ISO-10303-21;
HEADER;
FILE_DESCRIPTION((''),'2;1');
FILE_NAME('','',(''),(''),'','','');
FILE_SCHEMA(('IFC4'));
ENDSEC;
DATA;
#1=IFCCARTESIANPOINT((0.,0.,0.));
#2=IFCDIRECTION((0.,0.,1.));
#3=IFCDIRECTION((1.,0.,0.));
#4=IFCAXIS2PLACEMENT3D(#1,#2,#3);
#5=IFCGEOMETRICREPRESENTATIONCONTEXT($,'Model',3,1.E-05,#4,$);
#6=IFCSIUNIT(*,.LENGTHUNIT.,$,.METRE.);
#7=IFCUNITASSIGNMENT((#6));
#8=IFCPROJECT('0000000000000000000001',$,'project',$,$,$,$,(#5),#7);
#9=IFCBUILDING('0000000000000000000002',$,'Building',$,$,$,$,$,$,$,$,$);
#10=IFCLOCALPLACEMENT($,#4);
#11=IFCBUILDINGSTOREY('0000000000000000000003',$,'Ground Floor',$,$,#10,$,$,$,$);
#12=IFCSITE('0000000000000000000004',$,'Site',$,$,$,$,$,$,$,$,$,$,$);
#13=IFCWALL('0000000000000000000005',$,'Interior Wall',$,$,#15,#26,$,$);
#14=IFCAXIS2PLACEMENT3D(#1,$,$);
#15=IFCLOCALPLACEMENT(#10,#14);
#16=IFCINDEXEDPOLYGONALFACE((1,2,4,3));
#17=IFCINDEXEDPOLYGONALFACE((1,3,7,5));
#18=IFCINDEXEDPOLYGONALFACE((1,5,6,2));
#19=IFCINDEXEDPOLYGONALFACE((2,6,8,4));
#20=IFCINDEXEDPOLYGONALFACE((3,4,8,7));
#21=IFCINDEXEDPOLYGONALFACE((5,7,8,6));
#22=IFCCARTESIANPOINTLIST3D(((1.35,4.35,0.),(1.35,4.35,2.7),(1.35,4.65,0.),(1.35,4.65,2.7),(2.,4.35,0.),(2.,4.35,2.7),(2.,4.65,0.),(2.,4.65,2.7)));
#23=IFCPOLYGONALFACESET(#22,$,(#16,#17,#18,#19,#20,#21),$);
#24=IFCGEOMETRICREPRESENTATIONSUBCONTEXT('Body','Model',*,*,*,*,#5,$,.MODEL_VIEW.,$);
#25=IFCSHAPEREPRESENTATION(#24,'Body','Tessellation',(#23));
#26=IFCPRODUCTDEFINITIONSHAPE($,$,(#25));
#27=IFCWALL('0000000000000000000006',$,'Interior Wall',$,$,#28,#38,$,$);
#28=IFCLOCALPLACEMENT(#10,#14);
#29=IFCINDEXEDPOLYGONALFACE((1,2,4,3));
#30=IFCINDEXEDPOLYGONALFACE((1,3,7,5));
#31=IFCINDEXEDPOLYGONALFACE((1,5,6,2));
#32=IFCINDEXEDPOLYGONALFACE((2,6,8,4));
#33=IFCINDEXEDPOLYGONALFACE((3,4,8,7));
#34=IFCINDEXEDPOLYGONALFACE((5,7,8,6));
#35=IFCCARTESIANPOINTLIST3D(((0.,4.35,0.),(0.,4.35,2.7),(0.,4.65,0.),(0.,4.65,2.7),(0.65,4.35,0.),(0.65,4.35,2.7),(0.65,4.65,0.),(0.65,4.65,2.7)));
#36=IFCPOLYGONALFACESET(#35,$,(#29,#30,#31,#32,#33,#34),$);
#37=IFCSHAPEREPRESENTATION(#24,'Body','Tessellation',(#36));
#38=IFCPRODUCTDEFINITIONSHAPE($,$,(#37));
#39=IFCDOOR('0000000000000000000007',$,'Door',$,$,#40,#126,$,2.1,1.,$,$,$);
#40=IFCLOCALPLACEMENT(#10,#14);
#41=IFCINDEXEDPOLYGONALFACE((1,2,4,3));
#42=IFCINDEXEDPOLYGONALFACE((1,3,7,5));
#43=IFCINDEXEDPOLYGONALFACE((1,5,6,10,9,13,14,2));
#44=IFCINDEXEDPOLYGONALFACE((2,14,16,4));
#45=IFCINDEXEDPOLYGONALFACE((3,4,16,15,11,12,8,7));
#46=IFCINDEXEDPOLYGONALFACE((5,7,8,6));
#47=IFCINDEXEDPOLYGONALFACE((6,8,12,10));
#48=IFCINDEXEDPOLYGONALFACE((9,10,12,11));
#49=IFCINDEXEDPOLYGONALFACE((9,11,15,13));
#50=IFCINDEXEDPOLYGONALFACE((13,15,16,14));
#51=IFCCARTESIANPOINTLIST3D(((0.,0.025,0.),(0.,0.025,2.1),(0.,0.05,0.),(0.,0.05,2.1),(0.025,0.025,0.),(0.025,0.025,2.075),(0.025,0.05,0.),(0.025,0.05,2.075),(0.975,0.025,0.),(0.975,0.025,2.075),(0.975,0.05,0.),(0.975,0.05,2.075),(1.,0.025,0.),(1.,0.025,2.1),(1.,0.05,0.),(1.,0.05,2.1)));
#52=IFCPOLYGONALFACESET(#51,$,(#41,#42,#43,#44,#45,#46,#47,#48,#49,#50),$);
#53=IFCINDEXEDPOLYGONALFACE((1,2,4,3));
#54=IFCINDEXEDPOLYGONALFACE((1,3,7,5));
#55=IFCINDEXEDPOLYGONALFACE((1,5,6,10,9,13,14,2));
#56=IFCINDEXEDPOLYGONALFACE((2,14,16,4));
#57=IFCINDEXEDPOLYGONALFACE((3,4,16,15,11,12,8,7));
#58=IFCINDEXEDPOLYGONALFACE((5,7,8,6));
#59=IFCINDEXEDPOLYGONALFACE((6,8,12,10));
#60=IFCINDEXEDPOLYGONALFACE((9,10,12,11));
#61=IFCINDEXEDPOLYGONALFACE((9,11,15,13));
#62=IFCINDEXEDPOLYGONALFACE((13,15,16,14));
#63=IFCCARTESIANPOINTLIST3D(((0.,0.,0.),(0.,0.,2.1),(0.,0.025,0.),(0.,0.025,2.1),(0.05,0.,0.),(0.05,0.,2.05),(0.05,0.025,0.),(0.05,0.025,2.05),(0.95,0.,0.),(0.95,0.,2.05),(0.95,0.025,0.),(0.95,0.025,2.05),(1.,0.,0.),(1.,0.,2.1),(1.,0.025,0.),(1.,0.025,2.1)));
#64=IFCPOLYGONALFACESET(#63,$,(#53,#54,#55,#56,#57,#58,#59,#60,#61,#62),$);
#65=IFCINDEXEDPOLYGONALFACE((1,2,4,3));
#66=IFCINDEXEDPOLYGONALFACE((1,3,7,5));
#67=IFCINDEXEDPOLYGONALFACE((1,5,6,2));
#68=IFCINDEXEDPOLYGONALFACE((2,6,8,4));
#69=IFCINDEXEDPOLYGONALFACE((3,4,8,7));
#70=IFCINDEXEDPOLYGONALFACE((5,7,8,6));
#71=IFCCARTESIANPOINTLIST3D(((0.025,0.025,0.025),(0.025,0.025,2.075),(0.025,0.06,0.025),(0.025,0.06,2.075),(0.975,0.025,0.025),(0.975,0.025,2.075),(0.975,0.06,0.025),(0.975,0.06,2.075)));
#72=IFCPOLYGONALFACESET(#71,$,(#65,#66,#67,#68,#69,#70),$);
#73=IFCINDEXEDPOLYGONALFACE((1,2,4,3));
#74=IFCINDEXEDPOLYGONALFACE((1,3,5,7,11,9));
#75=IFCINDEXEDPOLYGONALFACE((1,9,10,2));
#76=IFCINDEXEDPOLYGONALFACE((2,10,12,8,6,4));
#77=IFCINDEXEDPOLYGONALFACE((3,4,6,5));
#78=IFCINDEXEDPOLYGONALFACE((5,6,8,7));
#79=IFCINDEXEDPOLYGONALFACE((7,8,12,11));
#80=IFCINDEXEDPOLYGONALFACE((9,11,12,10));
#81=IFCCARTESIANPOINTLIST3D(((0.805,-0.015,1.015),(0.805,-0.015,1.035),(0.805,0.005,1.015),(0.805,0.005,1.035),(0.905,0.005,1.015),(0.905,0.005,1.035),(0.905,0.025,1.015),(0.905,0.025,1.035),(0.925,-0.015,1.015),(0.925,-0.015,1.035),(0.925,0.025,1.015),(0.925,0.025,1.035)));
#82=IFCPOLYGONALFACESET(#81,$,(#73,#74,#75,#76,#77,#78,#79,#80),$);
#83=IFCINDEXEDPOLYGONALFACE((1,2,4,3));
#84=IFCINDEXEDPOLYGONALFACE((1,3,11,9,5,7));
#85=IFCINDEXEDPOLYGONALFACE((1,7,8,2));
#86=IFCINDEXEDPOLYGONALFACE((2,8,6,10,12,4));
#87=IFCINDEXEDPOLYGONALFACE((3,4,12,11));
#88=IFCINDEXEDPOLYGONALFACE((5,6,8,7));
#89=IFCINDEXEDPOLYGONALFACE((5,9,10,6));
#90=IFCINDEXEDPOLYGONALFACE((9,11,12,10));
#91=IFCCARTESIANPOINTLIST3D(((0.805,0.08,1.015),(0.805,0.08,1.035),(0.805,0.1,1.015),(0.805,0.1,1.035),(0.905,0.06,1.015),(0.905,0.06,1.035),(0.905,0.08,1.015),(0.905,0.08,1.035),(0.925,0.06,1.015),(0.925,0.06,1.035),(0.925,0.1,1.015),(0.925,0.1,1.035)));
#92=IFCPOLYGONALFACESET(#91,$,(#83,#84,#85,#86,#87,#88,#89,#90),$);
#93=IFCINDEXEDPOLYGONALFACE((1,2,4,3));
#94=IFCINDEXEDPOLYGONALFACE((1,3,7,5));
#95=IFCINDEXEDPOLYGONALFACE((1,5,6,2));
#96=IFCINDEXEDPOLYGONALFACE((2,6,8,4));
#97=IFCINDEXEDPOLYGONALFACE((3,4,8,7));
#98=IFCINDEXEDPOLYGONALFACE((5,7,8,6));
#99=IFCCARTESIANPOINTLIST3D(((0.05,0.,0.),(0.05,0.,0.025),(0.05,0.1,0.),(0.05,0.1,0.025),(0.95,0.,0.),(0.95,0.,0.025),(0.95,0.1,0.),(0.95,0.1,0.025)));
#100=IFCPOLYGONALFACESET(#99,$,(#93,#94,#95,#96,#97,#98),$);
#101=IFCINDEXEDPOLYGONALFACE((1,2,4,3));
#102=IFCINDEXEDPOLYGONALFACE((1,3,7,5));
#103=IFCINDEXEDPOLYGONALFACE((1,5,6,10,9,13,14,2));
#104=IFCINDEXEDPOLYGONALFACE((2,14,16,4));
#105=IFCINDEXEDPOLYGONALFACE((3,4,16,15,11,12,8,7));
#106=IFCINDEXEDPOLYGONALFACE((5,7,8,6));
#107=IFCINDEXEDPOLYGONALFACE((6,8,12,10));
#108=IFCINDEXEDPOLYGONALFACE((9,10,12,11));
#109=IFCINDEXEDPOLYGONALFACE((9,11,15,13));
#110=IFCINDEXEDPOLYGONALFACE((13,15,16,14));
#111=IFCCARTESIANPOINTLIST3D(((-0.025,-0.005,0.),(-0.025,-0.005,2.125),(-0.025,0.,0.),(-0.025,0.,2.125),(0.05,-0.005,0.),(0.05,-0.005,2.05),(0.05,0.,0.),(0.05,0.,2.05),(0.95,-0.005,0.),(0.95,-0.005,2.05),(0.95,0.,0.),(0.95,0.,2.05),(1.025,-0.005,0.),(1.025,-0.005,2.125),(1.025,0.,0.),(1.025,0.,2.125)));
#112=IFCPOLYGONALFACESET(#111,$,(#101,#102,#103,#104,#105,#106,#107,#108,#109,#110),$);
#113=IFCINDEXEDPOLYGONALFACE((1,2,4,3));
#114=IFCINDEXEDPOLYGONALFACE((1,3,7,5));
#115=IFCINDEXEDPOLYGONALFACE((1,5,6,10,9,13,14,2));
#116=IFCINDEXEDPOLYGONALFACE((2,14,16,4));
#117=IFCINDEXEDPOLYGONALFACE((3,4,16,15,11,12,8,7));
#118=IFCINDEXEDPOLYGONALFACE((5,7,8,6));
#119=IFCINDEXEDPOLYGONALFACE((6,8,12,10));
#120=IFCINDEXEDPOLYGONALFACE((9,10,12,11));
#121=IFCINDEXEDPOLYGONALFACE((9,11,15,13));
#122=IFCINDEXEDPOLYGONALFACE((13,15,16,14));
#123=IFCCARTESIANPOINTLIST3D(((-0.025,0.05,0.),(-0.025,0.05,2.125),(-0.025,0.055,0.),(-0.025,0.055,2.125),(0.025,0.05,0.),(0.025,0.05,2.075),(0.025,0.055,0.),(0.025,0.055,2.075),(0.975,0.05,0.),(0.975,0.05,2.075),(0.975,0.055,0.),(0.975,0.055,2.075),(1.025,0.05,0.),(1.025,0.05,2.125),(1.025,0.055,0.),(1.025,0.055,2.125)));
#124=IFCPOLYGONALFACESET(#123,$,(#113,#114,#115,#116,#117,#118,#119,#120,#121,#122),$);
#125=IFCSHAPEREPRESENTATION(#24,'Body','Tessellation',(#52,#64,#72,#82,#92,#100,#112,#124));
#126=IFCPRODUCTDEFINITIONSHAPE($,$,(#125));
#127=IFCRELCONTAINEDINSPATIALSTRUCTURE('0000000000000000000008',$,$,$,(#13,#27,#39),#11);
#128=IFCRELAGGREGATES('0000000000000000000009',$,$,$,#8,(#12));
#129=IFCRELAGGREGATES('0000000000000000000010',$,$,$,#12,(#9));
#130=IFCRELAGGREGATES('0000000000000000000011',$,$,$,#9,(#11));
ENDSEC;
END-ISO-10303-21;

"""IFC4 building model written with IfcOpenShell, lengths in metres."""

from ifc_helpers import new_model, si_unit, frame, origin_with_axes, place, context, subcontext, project, spatial, line, indexed_curve, outline, extrude, element, save


model = new_model("IFC4")

# Units and contexts
model_context = context("Model", 3, precision=1e-05, world=origin_with_axes())
body_context = subcontext(model_context, "Body", "Model", "MODEL_VIEW")
ifc_project = project(units=[si_unit("LENGTHUNIT", "METRE")], contexts=[model_context])

# Site, building, storey
site = spatial("IfcSite", under=ifc_project, Name="Site")
building = spatial("IfcBuilding", under=site, Name="Building")
storey_placement = place(None, origin_with_axes())
storey = spatial("IfcBuildingStorey", under=building, at=storey_placement, Name="Ground Floor")

# Walls
for number, where, z_axis, x_axis, name in (
    (1, (2.0, 4.5, 0.0), (0.0, 0.0, 1.0), (-1.0, 0.0, 0.0), "Interior Wall"),
    (2, (0.65, 4.5, 0.0), (0.0, 0.0, 1.0), (-1.0, 0.0, 0.0), "Interior Wall"),
):
    element("IfcWall", number, at=place(storey_placement, frame(where, z_axis=z_axis, x_axis=x_axis)), inside=storey, Name=name, context=body_context, shape_type="SweptSolid", body=[
        extrude(outline(indexed_curve([(0.0, 0.0), (0.0, 0.3), (0.65, 0.3), (0.65, 0.0), (0.0, 0.0)], self_intersect=False)), frame((0.0, -0.15, 0.0), z_axis=(0.0, 0.0, 1.0), x_axis=(1.0, 0.0, 0.0)), (0.0, 0.0, 1.0), 2.7),
    ])

# Door
door_1_placement = place(storey_placement, origin_with_axes())
element("IfcDoor", 3, at=door_1_placement, inside=storey, Name="Door", OverallHeight=2.1, OverallWidth=1.0, context=body_context, shape_type="SweptSolid", body=[
    extrude(outline(indexed_curve([(0.0, 0.0), (0.0, 2.1), (1.0, 2.1), (1.0, 0.0), (0.975, 0.0), (0.975, 2.075), (0.025, 2.075), (0.025, 0.0)], segments=[line(1, 2, 3, 4, 5, 6, 7, 8, 1)])), frame((0.0, 0.025, 0.0), z_axis=(0.0, -1.0, 0.0), x_axis=(1.0, 0.0, 0.0)), (0.0, 0.0, -1.0), 0.025),
    extrude(outline(indexed_curve([(0.0, 0.0), (0.0, 2.1), (1.0, 2.1), (1.0, 0.0), (0.95, 0.0), (0.95, 2.05), (0.05, 2.05), (0.05, 0.0)], segments=[line(1, 2, 3, 4, 5, 6, 7, 8, 1)])), frame((0.0, 0.0, 0.0), z_axis=(0.0, -1.0, 0.0), x_axis=(1.0, 0.0, 0.0)), (0.0, 0.0, -1.0), 0.025),
    extrude(outline(indexed_curve([(0.0, 0.0), (0.95, 0.0), (0.95, 0.035), (0.0, 0.035)], segments=[line(1, 2, 3, 4, 1)])), frame((0.025, 0.025, 0.025), z_axis=(0.0, 0.0, 1.0), x_axis=(1.0, 0.0, 0.0)), (0.0, 0.0, 1.0), 2.05),
    extrude(outline(indexed_curve([(0.0, 0.0), (0.0, -0.04), (-0.12, -0.04), (-0.12, -0.02), (-0.02, -0.02), (-0.02, 0.0)], segments=[line(1, 2, 3, 4, 5, 6, 1)])), frame((0.925, 0.025, 1.015), z_axis=(0.0, 0.0, 1.0), x_axis=(1.0, 0.0, 0.0)), (0.0, 0.0, 1.0), 0.02),
    extrude(outline(indexed_curve([(0.0, 0.0), (0.0, 0.04), (-0.12, 0.04), (-0.12, 0.02), (-0.02, 0.02), (-0.02, 0.0)], segments=[line(1, 2, 3, 4, 5, 6, 1)])), frame((0.925, 0.06, 1.015), z_axis=(0.0, 0.0, 1.0), x_axis=(1.0, 0.0, 0.0)), (0.0, 0.0, 1.0), 0.02),
    extrude(outline(indexed_curve([(0.0, 0.0), (0.9, 0.0), (0.9, 0.1), (0.0, 0.1)], segments=[line(1, 2, 3, 4, 1)])), frame((0.05, 0.0, 0.0), z_axis=(0.0, 0.0, 1.0), x_axis=(1.0, 0.0, 0.0)), (0.0, 0.0, 1.0), 0.025),
    extrude(outline(indexed_curve([(0.0, 0.0), (0.0, 2.125), (1.05, 2.125), (1.05, 0.0), (0.975, 0.0), (0.975, 2.05), (0.075, 2.05), (0.075, 0.0)], segments=[line(1, 2, 3, 4, 5, 6, 7, 8, 1)])), frame((-0.025, -0.005, 0.0), z_axis=(0.0, -1.0, 0.0), x_axis=(1.0, 0.0, 0.0)), (0.0, 0.0, -1.0), 0.005),
    extrude(outline(indexed_curve([(0.0, 0.0), (0.0, 2.125), (1.05, 2.125), (1.05, 0.0), (1.0, 0.0), (1.0, 2.075), (0.05, 2.075), (0.05, 0.0)], segments=[line(1, 2, 3, 4, 5, 6, 7, 8, 1)])), frame((-0.025, 0.05, 0.0), z_axis=(0.0, -1.0, 0.0), x_axis=(1.0, 0.0, 0.0)), (0.0, 0.0, -1.0), 0.005),
])

save(model, "model.ifc")
